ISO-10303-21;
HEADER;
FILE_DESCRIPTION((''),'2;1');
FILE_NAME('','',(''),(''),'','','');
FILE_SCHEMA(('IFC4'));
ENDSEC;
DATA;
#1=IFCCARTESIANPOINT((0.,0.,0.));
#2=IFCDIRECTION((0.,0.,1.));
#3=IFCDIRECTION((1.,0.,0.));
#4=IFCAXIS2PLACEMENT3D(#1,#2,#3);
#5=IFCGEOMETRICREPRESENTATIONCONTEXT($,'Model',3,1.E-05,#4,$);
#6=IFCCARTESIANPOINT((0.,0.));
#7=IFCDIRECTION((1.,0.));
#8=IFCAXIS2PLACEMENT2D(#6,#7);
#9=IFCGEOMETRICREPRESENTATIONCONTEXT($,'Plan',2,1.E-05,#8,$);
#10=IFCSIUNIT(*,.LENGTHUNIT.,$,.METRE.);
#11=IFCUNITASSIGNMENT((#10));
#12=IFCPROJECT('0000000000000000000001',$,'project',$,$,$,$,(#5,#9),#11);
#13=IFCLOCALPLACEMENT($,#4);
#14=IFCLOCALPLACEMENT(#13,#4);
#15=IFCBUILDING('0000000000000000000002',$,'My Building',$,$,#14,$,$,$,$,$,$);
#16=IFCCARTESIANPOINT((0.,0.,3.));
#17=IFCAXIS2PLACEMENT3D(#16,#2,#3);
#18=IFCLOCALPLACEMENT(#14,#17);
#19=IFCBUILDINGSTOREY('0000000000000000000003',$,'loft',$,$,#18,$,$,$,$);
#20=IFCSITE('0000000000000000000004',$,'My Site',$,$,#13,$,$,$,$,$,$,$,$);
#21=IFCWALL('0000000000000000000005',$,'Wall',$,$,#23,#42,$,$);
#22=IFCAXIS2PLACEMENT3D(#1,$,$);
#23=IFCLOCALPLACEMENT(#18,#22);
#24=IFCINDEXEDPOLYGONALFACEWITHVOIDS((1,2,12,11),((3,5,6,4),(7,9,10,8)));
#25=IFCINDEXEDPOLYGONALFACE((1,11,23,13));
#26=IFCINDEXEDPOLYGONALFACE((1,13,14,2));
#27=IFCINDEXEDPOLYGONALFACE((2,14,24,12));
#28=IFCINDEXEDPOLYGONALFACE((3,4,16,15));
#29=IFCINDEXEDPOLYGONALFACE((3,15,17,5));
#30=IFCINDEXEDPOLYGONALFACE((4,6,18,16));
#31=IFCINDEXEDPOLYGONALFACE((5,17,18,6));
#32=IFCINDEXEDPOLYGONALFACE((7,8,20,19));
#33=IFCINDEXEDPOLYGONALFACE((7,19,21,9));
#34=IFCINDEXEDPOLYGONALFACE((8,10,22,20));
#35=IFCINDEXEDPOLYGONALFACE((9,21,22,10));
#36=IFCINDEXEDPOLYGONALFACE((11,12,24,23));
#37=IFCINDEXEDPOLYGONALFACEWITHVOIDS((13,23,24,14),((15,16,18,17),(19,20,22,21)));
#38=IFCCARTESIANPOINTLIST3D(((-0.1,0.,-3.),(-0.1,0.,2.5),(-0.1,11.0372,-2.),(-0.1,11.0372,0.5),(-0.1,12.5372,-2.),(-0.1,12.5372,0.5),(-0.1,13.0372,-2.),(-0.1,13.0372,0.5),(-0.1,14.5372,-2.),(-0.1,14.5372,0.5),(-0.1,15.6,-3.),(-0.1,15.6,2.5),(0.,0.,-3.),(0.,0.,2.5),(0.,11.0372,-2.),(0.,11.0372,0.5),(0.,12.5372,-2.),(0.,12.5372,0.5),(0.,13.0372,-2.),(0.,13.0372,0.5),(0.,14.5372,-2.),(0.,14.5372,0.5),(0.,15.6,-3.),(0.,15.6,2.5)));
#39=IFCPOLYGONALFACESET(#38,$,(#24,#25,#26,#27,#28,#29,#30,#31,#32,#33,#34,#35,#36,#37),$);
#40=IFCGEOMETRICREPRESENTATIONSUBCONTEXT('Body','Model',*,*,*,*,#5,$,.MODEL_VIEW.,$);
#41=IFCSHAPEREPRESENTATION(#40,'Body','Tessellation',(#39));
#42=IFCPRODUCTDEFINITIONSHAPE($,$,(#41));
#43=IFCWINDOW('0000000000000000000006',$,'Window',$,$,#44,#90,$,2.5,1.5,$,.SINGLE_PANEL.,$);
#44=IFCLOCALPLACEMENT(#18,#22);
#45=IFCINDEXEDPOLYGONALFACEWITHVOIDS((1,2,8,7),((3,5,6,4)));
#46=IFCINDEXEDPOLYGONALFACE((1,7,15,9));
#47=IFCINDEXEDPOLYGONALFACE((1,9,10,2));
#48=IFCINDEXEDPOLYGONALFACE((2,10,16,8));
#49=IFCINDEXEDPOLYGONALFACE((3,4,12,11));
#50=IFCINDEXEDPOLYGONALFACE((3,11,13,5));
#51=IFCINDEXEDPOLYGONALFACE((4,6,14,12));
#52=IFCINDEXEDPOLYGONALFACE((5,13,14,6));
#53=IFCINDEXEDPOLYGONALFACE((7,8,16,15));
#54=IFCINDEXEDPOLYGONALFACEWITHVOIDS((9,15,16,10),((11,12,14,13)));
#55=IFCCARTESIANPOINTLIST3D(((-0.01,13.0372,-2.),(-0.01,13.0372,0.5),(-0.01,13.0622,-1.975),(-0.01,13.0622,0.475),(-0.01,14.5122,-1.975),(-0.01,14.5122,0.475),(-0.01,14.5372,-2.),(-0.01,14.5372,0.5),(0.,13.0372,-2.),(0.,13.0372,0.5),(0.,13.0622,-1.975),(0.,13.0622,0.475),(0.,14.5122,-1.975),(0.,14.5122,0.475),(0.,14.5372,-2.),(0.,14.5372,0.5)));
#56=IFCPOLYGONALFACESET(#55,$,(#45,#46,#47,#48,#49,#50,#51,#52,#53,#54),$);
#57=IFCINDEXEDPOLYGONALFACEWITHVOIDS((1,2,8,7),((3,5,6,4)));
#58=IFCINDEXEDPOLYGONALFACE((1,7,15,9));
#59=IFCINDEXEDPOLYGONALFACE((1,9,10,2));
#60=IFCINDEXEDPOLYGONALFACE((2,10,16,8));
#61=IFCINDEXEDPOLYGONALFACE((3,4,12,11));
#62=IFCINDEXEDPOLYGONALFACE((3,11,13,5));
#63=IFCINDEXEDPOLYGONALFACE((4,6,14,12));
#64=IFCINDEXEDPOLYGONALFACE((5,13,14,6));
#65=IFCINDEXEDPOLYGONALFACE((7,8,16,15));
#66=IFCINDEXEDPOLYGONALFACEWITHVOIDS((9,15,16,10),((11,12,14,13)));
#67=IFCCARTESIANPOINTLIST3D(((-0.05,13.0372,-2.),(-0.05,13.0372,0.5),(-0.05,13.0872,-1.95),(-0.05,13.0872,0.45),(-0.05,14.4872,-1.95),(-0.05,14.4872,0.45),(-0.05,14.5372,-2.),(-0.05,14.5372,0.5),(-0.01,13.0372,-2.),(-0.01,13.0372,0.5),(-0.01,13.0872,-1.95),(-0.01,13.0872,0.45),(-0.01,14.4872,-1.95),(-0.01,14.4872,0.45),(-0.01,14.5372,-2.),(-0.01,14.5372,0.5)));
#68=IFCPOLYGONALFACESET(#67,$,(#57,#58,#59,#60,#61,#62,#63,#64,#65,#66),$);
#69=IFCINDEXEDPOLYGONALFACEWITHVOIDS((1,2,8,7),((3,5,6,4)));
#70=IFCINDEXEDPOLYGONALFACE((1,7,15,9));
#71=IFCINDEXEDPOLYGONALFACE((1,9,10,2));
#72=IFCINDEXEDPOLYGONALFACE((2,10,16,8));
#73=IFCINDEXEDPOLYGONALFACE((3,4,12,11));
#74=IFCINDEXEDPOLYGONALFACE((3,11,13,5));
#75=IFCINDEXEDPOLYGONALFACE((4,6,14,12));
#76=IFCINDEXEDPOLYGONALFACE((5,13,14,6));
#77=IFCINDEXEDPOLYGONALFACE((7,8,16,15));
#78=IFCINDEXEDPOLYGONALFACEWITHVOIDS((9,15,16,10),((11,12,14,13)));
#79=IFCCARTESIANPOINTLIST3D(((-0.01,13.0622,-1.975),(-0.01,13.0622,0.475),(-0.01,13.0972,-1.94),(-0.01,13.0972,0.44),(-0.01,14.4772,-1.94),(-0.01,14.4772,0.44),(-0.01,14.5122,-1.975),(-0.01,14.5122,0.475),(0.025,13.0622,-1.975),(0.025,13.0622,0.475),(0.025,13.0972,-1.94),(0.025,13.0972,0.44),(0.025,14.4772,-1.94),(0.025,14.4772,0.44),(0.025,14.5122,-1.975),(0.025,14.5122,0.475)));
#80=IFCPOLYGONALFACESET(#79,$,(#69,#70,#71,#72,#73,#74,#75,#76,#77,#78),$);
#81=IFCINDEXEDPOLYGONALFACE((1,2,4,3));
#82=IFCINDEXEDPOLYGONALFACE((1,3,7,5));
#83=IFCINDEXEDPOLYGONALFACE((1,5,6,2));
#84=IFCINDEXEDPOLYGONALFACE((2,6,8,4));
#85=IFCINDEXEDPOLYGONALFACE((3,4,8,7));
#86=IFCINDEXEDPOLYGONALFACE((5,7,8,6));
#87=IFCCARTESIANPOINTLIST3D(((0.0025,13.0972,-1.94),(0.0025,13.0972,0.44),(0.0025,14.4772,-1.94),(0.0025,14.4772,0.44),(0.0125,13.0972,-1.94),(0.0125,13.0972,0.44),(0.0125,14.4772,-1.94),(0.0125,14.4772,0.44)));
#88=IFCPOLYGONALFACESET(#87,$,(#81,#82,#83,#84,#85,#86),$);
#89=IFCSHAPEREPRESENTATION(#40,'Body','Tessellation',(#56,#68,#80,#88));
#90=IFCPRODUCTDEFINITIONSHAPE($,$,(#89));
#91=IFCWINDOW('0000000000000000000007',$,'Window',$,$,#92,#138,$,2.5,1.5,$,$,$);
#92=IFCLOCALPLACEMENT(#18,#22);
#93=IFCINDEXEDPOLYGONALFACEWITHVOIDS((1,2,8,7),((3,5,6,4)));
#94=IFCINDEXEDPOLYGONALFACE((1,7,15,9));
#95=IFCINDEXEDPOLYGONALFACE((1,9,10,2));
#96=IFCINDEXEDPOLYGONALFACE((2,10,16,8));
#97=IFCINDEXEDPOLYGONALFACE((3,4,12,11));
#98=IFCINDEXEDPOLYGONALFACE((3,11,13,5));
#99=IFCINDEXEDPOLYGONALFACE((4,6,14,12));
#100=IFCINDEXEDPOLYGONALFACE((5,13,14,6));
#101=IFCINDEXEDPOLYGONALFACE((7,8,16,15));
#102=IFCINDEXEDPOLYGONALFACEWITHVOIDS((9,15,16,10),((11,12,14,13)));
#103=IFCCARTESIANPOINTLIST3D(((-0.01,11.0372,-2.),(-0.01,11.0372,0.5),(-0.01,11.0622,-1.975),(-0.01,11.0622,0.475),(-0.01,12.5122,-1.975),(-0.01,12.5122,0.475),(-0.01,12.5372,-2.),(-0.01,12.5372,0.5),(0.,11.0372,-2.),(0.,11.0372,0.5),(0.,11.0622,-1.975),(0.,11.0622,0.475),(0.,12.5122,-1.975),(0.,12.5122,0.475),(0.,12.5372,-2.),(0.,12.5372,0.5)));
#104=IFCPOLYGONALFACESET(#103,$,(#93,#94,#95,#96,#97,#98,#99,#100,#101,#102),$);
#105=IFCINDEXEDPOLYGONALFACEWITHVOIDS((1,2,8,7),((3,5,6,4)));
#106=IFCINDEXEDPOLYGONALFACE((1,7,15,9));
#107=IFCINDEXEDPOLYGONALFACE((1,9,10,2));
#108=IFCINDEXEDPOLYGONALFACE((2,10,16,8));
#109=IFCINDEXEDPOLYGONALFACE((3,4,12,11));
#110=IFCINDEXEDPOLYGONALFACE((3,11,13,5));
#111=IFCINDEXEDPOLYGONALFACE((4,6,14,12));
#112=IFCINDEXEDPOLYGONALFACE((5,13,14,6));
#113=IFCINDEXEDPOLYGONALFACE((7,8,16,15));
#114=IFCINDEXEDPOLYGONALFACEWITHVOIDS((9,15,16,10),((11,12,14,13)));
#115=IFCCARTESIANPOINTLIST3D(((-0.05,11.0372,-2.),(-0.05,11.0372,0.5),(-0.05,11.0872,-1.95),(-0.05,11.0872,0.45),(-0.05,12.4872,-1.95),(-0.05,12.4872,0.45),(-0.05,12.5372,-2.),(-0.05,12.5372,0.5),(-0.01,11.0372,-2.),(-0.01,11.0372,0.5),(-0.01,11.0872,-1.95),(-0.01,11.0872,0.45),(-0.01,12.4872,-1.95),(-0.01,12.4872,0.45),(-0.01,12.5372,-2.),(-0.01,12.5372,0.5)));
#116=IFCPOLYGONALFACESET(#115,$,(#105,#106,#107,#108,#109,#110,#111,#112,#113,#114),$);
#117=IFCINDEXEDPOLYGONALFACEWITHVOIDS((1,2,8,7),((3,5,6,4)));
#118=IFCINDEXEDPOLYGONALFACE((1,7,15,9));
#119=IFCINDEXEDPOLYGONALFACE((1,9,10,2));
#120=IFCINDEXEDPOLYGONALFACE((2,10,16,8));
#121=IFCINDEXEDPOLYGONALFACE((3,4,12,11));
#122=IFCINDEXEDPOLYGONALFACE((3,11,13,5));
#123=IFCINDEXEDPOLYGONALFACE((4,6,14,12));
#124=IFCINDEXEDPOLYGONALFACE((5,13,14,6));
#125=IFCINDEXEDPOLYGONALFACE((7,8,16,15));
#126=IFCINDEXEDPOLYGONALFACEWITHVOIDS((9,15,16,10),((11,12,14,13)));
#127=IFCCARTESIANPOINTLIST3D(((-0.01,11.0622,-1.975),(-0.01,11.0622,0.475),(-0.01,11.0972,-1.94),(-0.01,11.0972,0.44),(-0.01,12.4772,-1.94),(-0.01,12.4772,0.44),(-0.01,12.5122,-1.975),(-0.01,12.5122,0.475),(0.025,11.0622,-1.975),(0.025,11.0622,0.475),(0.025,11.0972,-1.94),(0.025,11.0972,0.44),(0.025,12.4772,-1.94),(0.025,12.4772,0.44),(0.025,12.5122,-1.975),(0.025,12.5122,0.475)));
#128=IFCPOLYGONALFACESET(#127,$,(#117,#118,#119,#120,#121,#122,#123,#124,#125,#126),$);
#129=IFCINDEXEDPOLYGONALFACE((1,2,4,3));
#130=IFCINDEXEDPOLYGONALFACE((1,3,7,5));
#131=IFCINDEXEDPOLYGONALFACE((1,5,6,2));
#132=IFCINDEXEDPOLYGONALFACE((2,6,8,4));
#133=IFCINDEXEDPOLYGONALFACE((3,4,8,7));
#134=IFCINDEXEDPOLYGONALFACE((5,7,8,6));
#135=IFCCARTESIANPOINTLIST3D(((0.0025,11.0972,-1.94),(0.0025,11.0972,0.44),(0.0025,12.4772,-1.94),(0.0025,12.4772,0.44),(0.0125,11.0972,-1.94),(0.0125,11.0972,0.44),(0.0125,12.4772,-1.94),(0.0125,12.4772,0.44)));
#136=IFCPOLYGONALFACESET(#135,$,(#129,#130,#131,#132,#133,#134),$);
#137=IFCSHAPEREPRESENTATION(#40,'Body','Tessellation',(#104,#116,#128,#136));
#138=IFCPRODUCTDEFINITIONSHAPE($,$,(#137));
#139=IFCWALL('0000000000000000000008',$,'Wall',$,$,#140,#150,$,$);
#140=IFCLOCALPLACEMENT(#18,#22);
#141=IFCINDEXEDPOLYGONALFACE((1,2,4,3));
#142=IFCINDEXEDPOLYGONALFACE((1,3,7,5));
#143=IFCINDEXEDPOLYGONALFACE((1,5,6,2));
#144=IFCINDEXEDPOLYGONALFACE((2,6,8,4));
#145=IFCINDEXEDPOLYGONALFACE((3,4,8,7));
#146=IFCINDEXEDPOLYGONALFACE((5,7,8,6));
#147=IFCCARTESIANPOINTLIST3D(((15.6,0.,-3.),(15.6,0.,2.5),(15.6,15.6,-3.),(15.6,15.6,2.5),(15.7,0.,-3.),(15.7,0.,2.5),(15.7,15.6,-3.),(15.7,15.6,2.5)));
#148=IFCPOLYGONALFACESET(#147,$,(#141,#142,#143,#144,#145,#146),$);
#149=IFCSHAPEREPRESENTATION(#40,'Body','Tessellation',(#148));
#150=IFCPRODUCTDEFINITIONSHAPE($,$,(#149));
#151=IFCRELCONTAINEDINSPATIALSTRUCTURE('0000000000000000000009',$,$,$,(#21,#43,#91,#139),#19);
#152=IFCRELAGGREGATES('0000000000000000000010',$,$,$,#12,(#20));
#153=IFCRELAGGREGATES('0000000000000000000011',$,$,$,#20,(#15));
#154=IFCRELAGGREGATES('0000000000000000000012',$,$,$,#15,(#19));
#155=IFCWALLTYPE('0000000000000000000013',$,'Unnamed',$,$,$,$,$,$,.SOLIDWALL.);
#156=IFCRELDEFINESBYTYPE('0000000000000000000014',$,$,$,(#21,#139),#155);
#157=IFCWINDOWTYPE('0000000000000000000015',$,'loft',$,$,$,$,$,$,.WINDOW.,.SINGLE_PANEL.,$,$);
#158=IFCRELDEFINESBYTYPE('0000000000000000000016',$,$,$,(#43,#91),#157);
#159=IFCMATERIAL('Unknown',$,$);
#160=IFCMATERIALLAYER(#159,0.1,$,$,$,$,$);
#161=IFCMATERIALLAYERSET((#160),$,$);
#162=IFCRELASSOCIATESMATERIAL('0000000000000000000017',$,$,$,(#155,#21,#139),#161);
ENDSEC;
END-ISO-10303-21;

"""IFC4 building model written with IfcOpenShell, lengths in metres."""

from ifc_helpers import new_model, entity, si_unit, frame, origin_with_axes, origin_2d_with_axis, place, context, subcontext, project, spatial, line, indexed_curve, outline, extrude, shape, source, transform, mapped, material, layer, layer_set, layer_usage, type_object, type_shapes, element, fill, save


model = new_model("IFC4")

# Units and contexts
model_context = context("Model", 3, precision=1e-05, world=origin_with_axes())
plan_context = context("Plan", 2, precision=1e-05, world=origin_2d_with_axis())
body_context_1 = subcontext(model_context, "Body", "Model", "MODEL_VIEW")
body_context_2 = subcontext(plan_context, "Body", "Plan", "PLAN_VIEW")
ifc_project = project(units=[si_unit("LENGTHUNIT", "METRE")], contexts=[model_context, plan_context])

# Site, building, storey
site_placement = place(None, origin_with_axes())
site = spatial("IfcSite", under=ifc_project, at=site_placement, Name="My Site")
building_placement = place(site_placement, origin_with_axes())
building = spatial("IfcBuilding", under=site, at=building_placement, Name="My Building")
storey_placement = place(building_placement, frame((0.0, 0.0, 3.0), z_axis=(0.0, 0.0, 1.0), x_axis=(1.0, 0.0, 0.0)))
storey = spatial("IfcBuildingStorey", under=building, at=storey_placement, Name="loft")

# Shared definitions
ifc_material = material(Name="Unknown")

# Wall, openings, windows
ifc_layer_1 = layer(ifc_material, 0.1)
ifc_layer_set_1 = layer_set([ifc_layer_1])
ifc_layer_usage_1 = layer_usage(ifc_layer_set_1, "AXIS2", "POSITIVE", 0.0)
wall_type = type_object("IfcWallType", Name="Unnamed", PredefinedType="SOLIDWALL", material=ifc_layer_set_1)
wall_1_placement = place(storey_placement, frame((0.0, 0.0, -3.0), z_axis=(0.0, 0.0, 1.0), x_axis=(0.0, 1.0, 0.0)))
wall_1 = element("IfcWall", 1, at=wall_1_placement, inside=storey, type_object=wall_type, material=ifc_layer_usage_1, Name="Wall", context=body_context_1, shape_type="SweptSolid", body=[
    extrude(outline(indexed_curve([(0.0, 0.0), (0.0, 0.1), (15.6, 0.1), (15.6, 0.0)], segments=[line(1, 2, 3, 4, 1)])), origin_with_axes(), (0.0, 0.0, 1.0), 5.5),
])
shared_shape_1 = source(origin_with_axes(), body_context_1, "Body", "SweptSolid", [
    extrude(outline(indexed_curve([(0.0, 0.0), (1.5, 0.0), (1.5, 2.5), (0.0, 2.5)], segments=[line(1, 2, 3, 4, 1)])), frame((0.0, -0.6, 0.0), z_axis=(0.0, -1.0, 0.0), x_axis=(1.0, 0.0, 0.0)), (0.0, 0.0, -1.0), 1.2),
])
opening_1_placement = place(wall_1_placement, frame((14.5372, 0.1, 1.0), z_axis=(0.0, 0.0, 1.0), x_axis=(-1.0, 0.0, 0.0)))
opening_1 = element("IfcOpeningElement", 2, at=opening_1_placement, cuts=wall_1, PredefinedType="OPENING", context=body_context_1, shape_type="MappedRepresentation", body=[
    mapped(shared_shape_1, transform((0.0, 0.0, 0.0), x_axis=(1.0, 0.0, 0.0), y_axis=(0.0, 1.0, 0.0), z_axis=(0.0, 0.0, 1.0), scale=1.0)),
])
opening_2_placement = place(wall_1_placement, frame((12.5372, 0.1, 1.0), z_axis=(0.0, 0.0, 1.0), x_axis=(-1.0, 0.0, 0.0)))
opening_2 = element("IfcOpeningElement", 3, at=opening_2_placement, cuts=wall_1, PredefinedType="OPENING", context=body_context_1, shape_type="MappedRepresentation", body=[
    mapped(shared_shape_1, transform((0.0, 0.0, 0.0), x_axis=(1.0, 0.0, 0.0), y_axis=(0.0, 1.0, 0.0), z_axis=(0.0, 0.0, 1.0), scale=1.0)),
])
window_type = type_object("IfcWindowType", Name="loft", PartitioningType="SINGLE_PANEL", PredefinedType="WINDOW")
shared_shape_2 = source(origin_with_axes(), body_context_1, "Body", "SweptSolid", [
    extrude(outline(indexed_curve([(0.0, 0.0), (1.5, 0.0), (1.5, 2.5), (0.0, 2.5)], segments=[line(1, 2, 3, 4, 1)]), holes=[indexed_curve([(0.025, 0.025), (1.475, 0.025), (1.475, 2.475), (0.025, 2.475)], segments=[line(1, 2, 3, 4, 1)])]), frame((0.0, 0.09, 0.0), z_axis=(0.0, -1.0, 0.0), x_axis=(1.0, 0.0, 0.0)), (0.0, 0.0, -1.0), 0.01),
    extrude(outline(indexed_curve([(0.0, 0.0), (1.5, 0.0), (1.5, 2.5), (0.0, 2.5)], segments=[line(1, 2, 3, 4, 1)]), holes=[indexed_curve([(0.05, 0.05), (1.45, 0.05), (1.45, 2.45), (0.05, 2.45)], segments=[line(1, 2, 3, 4, 1)])]), frame((0.0, 0.05, 0.0), z_axis=(0.0, -1.0, 0.0), x_axis=(1.0, 0.0, 0.0)), (0.0, 0.0, -1.0), 0.04),
    extrude(outline(indexed_curve([(0.0, 0.0), (1.45, 0.0), (1.45, 2.45), (0.0, 2.45)], segments=[line(1, 2, 3, 4, 1)]), holes=[indexed_curve([(0.035, 0.035), (1.415, 0.035), (1.415, 2.415), (0.035, 2.415)], segments=[line(1, 2, 3, 4, 1)])]), frame((0.025, 0.09, 0.025), z_axis=(0.0, -1.0, 0.0), x_axis=(1.0, 0.0, 0.0)), (0.0, 0.0, -1.0), 0.035),
    extrude(outline(indexed_curve([(0.035, 0.035), (1.415, 0.035), (1.415, 2.415), (0.035, 2.415)], segments=[line(1, 2, 3, 4, 1)])), frame((0.025, 0.1025, 0.025), z_axis=(0.0, -1.0, 0.0), x_axis=(1.0, 0.0, 0.0)), (0.0, 0.0, -1.0), 0.01),
])
shared_shape_3 = source(origin_with_axes(), body_context_2, "Body", "Curve2D", [
    entity("IfcIndexedPolyCurve", entity("IfcCartesianPointList2D", [[0.05, 0.05], [1.45, 0.05]])),
    entity("IfcIndexedPolyCurve", entity("IfcCartesianPointList2D", [[0.0, 0.1], [0.025, 0.1], [0.025, 0.09], [0.05, 0.09], [0.05, 0.05], [0.0, 0.05]]), [entity("IfcLineIndex", [1, 2, 3, 4, 5, 6, 1])]),
    entity("IfcIndexedPolyCurve", entity("IfcCartesianPointList2D", [[1.5, 0.1], [1.475, 0.1], [1.475, 0.09], [1.45, 0.09], [1.45, 0.05], [1.5, 0.05]]), [entity("IfcLineIndex", [1, 2, 3, 4, 5, 6, 1])]),
    entity("IfcIndexedPolyCurve", entity("IfcCartesianPointList2D", [[0.025, 0.09], [0.06, 0.09], [0.06, 0.125], [0.025, 0.125]]), [entity("IfcLineIndex", [1, 2, 3, 4, 1])]),
    entity("IfcIndexedPolyCurve", entity("IfcCartesianPointList2D", [[1.475, 0.09], [1.44, 0.09], [1.44, 0.125], [1.475, 0.125]]), [entity("IfcLineIndex", [1, 2, 3, 4, 1])]),
    entity("IfcIndexedPolyCurve", entity("IfcCartesianPointList2D", [[0.06, 0.09], [1.44, 0.09]])),
    entity("IfcIndexedPolyCurve", entity("IfcCartesianPointList2D", [[0.06, 0.125], [1.44, 0.125]])),
    entity("IfcIndexedPolyCurve", entity("IfcCartesianPointList2D", [[0.06, 0.1075], [1.44, 0.1075]])),
])
type_shapes(window_type, [shared_shape_2, shared_shape_3])
window_1_placement = place(opening_1_placement, frame((0.0, 0.0, 0.0), z_axis=(0.0, 0.0, 1.0), x_axis=(1.0, 0.0, 0.0)))
window_1 = element("IfcWindow", 4, at=window_1_placement, inside=storey, type_object=window_type, Name="Window", OverallHeight=2.5, OverallWidth=1.5, PartitioningType="SINGLE_PANEL", shapes=[
    shape(body_context_1, "Body", "MappedRepresentation", [mapped(shared_shape_2, transform((0.0, 0.0, 0.0), x_axis=(1.0, 0.0, 0.0), y_axis=(0.0, 1.0, 0.0), z_axis=(0.0, 0.0, 1.0), scale=1.0))]),
    shape(body_context_2, "Body", "MappedRepresentation", [mapped(shared_shape_3, transform((0.0, 0.0, 0.0), x_axis=(1.0, 0.0, 0.0), y_axis=(0.0, 1.0, 0.0), z_axis=(0.0, 0.0, 1.0), scale=1.0))]),
])
fill(opening_1, window_1)
window_2_placement = place(opening_2_placement, frame((0.0, 0.0, 0.0), z_axis=(0.0, 0.0, 1.0), x_axis=(1.0, 0.0, 0.0)))
window_2 = element("IfcWindow", 5, at=window_2_placement, inside=storey, type_object=window_type, Name="Window", OverallHeight=2.5, OverallWidth=1.5, shapes=[
    shape(body_context_1, "Body", "MappedRepresentation", [mapped(shared_shape_2, transform((0.0, 0.0, 0.0), x_axis=(1.0, 0.0, 0.0), y_axis=(0.0, 1.0, 0.0), z_axis=(0.0, 0.0, 1.0), scale=1.0))]),
    shape(body_context_2, "Body", "MappedRepresentation", [mapped(shared_shape_3, transform((0.0, 0.0, 0.0), x_axis=(1.0, 0.0, 0.0), y_axis=(0.0, 1.0, 0.0), z_axis=(0.0, 0.0, 1.0), scale=1.0))]),
])
fill(opening_2, window_2)

# Wall
ifc_layer_usage_2 = layer_usage(ifc_layer_set_1, "AXIS2", "POSITIVE", 0.0)
wall_2_placement = place(storey_placement, frame((15.6, 15.6, -3.0), z_axis=(0.0, 0.0, 1.0), x_axis=(0.0, -1.0, 0.0)))
element("IfcWall", 6, at=wall_2_placement, inside=storey, type_object=wall_type, material=ifc_layer_usage_2, Name="Wall", context=body_context_1, shape_type="SweptSolid", body=[
    extrude(outline(indexed_curve([(0.0, 0.0), (0.0, 0.1), (15.6, 0.1), (15.6, 0.0)], segments=[line(1, 2, 3, 4, 1)])), origin_with_axes(), (0.0, 0.0, 1.0), 5.5),
])

save(model, "model.ifc")
